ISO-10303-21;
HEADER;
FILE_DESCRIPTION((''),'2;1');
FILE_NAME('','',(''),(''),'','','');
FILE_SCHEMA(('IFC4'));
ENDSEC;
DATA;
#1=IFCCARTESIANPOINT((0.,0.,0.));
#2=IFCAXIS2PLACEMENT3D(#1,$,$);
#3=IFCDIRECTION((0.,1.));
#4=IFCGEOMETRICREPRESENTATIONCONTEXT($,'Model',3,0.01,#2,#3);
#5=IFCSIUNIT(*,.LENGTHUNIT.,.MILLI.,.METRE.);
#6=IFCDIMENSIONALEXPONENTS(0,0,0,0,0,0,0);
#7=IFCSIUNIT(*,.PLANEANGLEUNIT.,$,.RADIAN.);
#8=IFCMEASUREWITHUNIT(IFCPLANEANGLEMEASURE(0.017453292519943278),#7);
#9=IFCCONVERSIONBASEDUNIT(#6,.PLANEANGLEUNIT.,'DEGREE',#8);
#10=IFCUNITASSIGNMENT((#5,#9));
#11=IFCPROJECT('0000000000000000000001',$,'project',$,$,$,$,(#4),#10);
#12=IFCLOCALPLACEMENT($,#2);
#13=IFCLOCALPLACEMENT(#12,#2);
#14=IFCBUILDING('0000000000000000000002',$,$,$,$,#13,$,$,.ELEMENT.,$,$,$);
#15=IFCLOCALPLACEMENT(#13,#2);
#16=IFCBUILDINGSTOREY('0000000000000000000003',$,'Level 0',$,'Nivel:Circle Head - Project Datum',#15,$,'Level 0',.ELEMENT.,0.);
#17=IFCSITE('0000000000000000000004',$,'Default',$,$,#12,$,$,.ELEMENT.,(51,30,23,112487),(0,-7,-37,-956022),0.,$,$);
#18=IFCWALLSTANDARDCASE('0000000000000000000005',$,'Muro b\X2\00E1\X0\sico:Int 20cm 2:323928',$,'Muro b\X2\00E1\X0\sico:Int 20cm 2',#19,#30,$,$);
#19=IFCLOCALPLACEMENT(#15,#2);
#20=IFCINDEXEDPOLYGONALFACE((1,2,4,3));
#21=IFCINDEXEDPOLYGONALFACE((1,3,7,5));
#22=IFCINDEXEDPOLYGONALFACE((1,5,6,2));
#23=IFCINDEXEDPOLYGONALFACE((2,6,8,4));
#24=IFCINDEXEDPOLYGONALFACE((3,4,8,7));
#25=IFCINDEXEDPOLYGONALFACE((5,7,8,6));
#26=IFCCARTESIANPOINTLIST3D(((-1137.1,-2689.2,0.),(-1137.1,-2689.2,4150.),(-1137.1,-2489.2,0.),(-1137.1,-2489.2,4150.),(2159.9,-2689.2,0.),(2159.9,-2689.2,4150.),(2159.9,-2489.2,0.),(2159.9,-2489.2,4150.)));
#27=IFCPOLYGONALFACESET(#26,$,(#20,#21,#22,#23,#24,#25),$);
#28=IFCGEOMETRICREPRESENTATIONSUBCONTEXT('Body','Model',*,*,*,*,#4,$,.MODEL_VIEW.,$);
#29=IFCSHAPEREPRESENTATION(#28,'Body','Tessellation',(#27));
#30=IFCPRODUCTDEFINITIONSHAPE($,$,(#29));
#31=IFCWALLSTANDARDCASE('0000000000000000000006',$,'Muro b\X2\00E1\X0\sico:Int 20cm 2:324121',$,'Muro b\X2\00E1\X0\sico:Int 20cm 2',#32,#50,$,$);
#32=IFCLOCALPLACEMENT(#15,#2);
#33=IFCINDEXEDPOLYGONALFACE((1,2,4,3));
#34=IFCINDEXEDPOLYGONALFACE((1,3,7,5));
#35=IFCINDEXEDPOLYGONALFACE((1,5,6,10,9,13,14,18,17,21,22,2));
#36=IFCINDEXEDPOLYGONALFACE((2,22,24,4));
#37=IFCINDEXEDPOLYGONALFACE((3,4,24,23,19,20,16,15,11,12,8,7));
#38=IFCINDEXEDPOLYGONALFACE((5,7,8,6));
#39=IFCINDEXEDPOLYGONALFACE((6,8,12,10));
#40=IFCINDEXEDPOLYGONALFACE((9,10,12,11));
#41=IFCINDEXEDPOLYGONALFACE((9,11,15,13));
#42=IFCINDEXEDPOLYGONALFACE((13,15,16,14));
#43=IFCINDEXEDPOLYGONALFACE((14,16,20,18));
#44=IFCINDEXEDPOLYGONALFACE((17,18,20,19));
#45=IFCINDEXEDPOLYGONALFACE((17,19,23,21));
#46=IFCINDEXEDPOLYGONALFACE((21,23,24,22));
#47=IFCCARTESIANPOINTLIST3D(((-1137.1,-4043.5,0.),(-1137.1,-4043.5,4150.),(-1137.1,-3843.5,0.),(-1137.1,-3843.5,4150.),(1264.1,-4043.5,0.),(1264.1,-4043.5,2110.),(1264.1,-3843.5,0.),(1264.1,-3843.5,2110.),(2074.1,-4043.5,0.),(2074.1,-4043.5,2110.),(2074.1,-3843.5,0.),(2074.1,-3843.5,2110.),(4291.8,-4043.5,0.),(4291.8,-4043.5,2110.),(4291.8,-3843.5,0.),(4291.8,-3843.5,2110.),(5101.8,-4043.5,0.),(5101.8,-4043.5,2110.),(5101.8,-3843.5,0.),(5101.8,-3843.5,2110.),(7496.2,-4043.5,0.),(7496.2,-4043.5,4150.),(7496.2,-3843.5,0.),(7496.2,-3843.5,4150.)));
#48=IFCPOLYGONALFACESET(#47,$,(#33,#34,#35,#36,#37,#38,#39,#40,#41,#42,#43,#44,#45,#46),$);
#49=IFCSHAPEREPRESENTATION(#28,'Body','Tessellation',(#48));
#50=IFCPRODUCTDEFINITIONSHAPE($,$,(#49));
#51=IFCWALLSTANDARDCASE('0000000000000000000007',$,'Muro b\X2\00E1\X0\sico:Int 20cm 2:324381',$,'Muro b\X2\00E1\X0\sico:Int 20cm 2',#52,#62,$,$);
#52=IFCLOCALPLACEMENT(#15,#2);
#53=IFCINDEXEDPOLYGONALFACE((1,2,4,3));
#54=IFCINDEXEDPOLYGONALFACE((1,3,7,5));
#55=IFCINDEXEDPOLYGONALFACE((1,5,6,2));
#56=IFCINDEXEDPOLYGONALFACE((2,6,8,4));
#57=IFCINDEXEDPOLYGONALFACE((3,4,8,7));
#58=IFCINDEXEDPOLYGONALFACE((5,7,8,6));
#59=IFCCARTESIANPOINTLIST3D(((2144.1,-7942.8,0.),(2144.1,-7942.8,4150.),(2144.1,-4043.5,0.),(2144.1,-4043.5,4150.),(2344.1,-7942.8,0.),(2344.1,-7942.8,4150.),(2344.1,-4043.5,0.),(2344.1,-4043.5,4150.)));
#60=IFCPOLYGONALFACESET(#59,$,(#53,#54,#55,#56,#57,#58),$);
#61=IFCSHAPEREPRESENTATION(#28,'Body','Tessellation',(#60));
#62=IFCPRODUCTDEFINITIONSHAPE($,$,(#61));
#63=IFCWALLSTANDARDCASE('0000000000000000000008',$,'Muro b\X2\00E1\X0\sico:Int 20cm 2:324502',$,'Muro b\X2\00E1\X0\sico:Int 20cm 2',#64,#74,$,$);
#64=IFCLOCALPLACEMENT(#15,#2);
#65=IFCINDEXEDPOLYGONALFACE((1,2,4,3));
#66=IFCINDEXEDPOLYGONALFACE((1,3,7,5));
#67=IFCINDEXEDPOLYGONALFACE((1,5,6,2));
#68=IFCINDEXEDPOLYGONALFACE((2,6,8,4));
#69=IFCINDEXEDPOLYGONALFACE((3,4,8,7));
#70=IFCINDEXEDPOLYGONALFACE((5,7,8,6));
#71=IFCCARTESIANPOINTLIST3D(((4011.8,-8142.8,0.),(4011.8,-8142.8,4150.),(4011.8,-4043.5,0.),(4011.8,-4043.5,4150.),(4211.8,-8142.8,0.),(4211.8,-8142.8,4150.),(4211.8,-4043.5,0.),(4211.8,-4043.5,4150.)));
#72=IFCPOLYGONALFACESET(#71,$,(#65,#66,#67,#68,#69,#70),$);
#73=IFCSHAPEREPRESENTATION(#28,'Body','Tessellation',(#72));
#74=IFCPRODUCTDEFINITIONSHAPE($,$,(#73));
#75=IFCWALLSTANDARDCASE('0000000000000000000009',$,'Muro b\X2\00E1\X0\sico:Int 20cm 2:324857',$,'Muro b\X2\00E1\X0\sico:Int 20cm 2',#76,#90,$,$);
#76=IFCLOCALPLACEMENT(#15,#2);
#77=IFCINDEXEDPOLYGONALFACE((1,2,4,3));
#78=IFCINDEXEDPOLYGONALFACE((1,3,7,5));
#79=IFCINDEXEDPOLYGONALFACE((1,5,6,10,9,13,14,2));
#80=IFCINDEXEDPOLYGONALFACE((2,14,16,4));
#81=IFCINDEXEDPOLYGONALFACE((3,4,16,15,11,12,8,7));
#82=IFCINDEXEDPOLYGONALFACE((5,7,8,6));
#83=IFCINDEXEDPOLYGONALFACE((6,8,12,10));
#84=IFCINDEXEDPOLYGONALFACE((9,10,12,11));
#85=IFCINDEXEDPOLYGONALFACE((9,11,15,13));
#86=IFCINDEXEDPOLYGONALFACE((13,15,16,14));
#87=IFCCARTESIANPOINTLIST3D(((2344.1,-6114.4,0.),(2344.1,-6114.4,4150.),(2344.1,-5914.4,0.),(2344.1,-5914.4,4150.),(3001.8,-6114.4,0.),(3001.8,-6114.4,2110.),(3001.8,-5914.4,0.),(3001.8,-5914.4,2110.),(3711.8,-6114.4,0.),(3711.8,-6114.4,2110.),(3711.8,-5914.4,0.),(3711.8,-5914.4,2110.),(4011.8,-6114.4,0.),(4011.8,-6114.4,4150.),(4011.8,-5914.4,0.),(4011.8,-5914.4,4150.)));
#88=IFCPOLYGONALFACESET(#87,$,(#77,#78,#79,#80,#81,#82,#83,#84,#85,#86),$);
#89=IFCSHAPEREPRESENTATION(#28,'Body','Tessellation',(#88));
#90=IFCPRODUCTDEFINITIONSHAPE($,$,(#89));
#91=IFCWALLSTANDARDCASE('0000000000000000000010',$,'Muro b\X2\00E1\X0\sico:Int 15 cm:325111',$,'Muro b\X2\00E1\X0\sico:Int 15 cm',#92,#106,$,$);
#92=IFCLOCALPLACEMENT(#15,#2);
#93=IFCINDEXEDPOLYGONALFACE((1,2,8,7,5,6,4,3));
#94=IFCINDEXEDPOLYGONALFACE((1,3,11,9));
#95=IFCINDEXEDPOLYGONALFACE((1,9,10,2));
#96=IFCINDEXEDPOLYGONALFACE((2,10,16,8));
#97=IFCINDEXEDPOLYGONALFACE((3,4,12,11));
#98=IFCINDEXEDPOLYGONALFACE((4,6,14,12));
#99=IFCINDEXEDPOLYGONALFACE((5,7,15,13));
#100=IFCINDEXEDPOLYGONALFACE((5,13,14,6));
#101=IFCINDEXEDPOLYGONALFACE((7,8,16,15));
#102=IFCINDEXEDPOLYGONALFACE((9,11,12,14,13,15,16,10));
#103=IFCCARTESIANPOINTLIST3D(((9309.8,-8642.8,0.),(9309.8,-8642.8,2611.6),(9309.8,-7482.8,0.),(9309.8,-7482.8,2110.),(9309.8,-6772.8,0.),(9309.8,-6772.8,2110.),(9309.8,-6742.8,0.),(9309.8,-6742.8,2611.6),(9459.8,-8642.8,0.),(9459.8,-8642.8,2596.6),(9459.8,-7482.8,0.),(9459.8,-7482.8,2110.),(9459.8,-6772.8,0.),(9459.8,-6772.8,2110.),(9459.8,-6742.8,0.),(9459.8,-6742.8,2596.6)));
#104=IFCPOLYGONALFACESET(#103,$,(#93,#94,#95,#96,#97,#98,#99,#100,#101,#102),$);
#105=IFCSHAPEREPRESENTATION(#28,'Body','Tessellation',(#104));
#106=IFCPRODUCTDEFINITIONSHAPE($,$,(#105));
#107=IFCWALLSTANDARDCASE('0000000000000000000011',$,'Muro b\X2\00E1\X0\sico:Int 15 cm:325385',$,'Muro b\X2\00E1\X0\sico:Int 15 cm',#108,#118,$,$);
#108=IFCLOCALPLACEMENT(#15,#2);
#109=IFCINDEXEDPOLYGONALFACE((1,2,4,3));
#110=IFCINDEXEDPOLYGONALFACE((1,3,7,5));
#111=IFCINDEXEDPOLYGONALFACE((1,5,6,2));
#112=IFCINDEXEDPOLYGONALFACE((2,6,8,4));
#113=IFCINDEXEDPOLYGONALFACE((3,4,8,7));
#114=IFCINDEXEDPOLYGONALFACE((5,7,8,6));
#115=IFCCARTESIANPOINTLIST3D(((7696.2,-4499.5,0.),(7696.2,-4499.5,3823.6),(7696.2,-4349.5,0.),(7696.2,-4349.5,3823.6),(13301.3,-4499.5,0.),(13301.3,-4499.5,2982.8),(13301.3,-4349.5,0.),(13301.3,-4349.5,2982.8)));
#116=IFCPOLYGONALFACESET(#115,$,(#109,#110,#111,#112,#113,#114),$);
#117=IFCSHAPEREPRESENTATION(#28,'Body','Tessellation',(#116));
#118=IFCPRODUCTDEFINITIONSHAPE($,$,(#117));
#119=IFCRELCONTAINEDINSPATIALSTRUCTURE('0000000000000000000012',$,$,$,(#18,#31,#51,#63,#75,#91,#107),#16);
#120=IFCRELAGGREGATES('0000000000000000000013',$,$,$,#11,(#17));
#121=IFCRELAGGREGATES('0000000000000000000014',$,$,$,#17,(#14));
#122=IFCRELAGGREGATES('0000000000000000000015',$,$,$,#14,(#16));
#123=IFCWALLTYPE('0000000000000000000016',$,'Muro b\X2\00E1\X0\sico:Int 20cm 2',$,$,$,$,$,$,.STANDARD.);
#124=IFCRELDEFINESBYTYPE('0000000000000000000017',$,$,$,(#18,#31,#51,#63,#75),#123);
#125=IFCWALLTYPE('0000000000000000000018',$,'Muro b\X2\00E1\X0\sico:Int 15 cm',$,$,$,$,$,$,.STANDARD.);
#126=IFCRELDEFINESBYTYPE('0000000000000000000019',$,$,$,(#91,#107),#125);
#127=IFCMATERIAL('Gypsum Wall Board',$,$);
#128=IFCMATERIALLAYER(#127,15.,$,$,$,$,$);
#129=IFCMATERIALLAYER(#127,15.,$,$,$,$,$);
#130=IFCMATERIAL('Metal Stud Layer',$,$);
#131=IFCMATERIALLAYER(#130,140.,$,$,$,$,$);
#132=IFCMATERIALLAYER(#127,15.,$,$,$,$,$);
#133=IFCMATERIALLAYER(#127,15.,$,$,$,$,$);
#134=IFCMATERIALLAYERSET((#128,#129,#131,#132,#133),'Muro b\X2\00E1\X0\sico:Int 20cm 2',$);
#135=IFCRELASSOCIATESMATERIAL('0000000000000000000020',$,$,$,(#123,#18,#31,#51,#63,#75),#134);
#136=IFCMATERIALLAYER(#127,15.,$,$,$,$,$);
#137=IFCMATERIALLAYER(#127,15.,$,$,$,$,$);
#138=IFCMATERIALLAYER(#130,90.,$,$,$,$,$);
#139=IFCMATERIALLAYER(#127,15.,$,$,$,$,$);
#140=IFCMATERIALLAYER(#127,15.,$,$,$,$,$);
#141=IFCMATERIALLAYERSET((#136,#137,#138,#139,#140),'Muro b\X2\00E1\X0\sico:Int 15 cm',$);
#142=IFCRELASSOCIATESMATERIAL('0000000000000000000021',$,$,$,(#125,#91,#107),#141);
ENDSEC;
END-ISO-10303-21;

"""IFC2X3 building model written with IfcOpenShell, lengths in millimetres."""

from ifc_helpers import new_model, entity, si_unit, converted_unit, direction, frame, frame_2d, origin, place, context, subcontext, project, spatial, polyline, rectangle, extrude, clip, bounded_halfspace, material, layer, layer_set, layer_usage, type_object, element, save


model = new_model("IFC2X3")

# Units and contexts
model_context = context("Model", 3, precision=0.01, world=origin(), true_north=direction((0.0, 1.0)))
body_context = subcontext(model_context, "Body", "Model", "MODEL_VIEW")
ifc_project = project(units=[si_unit("LENGTHUNIT", "METRE", prefix="MILLI"), converted_unit("PLANEANGLEUNIT", "DEGREE", entity("IfcPlaneAngleMeasure", 0.017453292519943278), si_unit("PLANEANGLEUNIT", "RADIAN"), dimensions=[0, 0, 0, 0, 0, 0, 0])], contexts=[model_context])

# Site, building, storey
site_placement = place(None, origin())
site = spatial("IfcSite", under=ifc_project, at=site_placement, Name="Default", CompositionType="ELEMENT", RefLatitude=(51, 30, 23, 112487), RefLongitude=(0, -7, -37, -956022), RefElevation=0.0)
building_placement = place(site_placement, origin())
building = spatial("IfcBuilding", under=site, at=building_placement, CompositionType="ELEMENT")
storey_placement = place(building_placement, origin())
storey = spatial("IfcBuildingStorey", under=building, at=storey_placement, Name="Level 0", ObjectType="Nivel:Circle Head - Project Datum", LongName="Level 0", CompositionType="ELEMENT", Elevation=0.0)

# Shared definitions
ifc_material_1 = material(Name="Gypsum Wall Board")
ifc_material_2 = material(Name="Metal Stud Layer")

# Wall
ifc_layer_1 = layer(ifc_material_1, 15.0)
ifc_layer_2 = layer(ifc_material_1, 15.0)
ifc_layer_3 = layer(ifc_material_2, 140.0)
ifc_layer_4 = layer(ifc_material_1, 15.0)
ifc_layer_5 = layer(ifc_material_1, 15.0)
ifc_layer_set_1 = layer_set([ifc_layer_1, ifc_layer_2, ifc_layer_3, ifc_layer_4, ifc_layer_5], Name="Muro básico:Int 20cm 2")
ifc_layer_usage_1 = layer_usage(ifc_layer_set_1, "AXIS2", "NEGATIVE", 100.0)
wall_type_1 = type_object("IfcWallType", Name="Muro básico:Int 20cm 2", PredefinedType="STANDARD", material=ifc_layer_set_1)
wall_1_placement = place(storey_placement, frame((-1137.1, -2589.2, 0.0)))
element("IfcWallStandardCase", 1, at=wall_1_placement, inside=storey, type_object=wall_type_1, material=ifc_layer_usage_1, Name="Muro básico:Int 20cm 2:323928", ObjectType="Muro básico:Int 20cm 2", context=body_context, shape_type="SweptSolid", body=[
    extrude(rectangle(XDim=3297.0, YDim=200.0, at=frame_2d((1648.5, 0.0), x_axis=(-1.0, 0.0))), origin(), (0.0, 0.0, 1.0), 4150.0),
])

# Wall, openings
ifc_layer_usage_2 = layer_usage(ifc_layer_set_1, "AXIS2", "NEGATIVE", 100.0)
wall_2_placement = place(storey_placement, frame((-1137.1, -3943.5, 0.0)))
wall_2 = element("IfcWallStandardCase", 2, at=wall_2_placement, inside=storey, type_object=wall_type_1, material=ifc_layer_usage_2, Name="Muro básico:Int 20cm 2:324121", ObjectType="Muro básico:Int 20cm 2", context=body_context, shape_type="SweptSolid", body=[
    extrude(rectangle(XDim=8633.4, YDim=200.0, at=frame_2d((4316.7, 0.0), x_axis=(-1.0, 0.0))), origin(), (0.0, 0.0, 1.0), 4150.0),
])
opening_1_placement = place(wall_2_placement, frame((3211.2, 100.0, 0.0)))
element("IfcOpeningElement", 3, at=opening_1_placement, cuts=wall_2, ObjectType="Opening", context=body_context, shape_type="SweptSolid", body=[
    extrude(rectangle(XDim=2110.0, YDim=810.0, at=frame_2d((1055.0, 405.0), x_axis=(1.0, 0.0))), frame((0.0, 0.0, 0.0), z_axis=(0.0, -1.0, 0.0), x_axis=(0.0, 0.0, 1.0)), (0.0, 0.0, 1.0), 200.0),
])
opening_2_placement = place(wall_2_placement, frame((6238.9, 100.0, 0.0)))
element("IfcOpeningElement", 4, at=opening_2_placement, cuts=wall_2, ObjectType="Opening", context=body_context, shape_type="SweptSolid", body=[
    extrude(rectangle(XDim=2110.0, YDim=810.0, at=frame_2d((1055.0, 405.0), x_axis=(1.0, 0.0))), frame((0.0, 0.0, 0.0), z_axis=(0.0, -1.0, 0.0), x_axis=(0.0, 0.0, 1.0)), (0.0, 0.0, 1.0), 200.0),
])

# Walls
ifc_layer_usage_3 = layer_usage(ifc_layer_set_1, "AXIS2", "NEGATIVE", 100.0)
wall_3_placement = place(storey_placement, frame((2244.1, -7942.8, 0.0), z_axis=(0.0, 0.0, 1.0), x_axis=(0.0, 1.0, 0.0)))
element("IfcWallStandardCase", 5, at=wall_3_placement, inside=storey, type_object=wall_type_1, material=ifc_layer_usage_3, Name="Muro básico:Int 20cm 2:324381", ObjectType="Muro básico:Int 20cm 2", context=body_context, shape_type="SweptSolid", body=[
    extrude(rectangle(XDim=3899.3, YDim=200.0, at=frame_2d((1949.6, 0.0), x_axis=(-1.0, 0.0))), origin(), (0.0, 0.0, 1.0), 4150.0),
])
ifc_layer_usage_4 = layer_usage(ifc_layer_set_1, "AXIS2", "NEGATIVE", 100.0)
wall_4_placement = place(storey_placement, frame((4111.8, -8142.8, 0.0), z_axis=(0.0, 0.0, 1.0), x_axis=(0.0, 1.0, 0.0)))
element("IfcWallStandardCase", 6, at=wall_4_placement, inside=storey, type_object=wall_type_1, material=ifc_layer_usage_4, Name="Muro básico:Int 20cm 2:324502", ObjectType="Muro básico:Int 20cm 2", context=body_context, shape_type="SweptSolid", body=[
    extrude(rectangle(XDim=4099.3, YDim=200.0, at=frame_2d((2049.6, 0.0), x_axis=(-1.0, 0.0))), origin(), (0.0, 0.0, 1.0), 4150.0),
])

# Walls, openings
ifc_layer_usage_5 = layer_usage(ifc_layer_set_1, "AXIS2", "NEGATIVE", 100.0)
wall_5_placement = place(storey_placement, frame((4011.8, -6014.4, 0.0), z_axis=(0.0, 0.0, 1.0), x_axis=(-1.0, 0.0, 0.0)))
wall_5 = element("IfcWallStandardCase", 7, at=wall_5_placement, inside=storey, type_object=wall_type_1, material=ifc_layer_usage_5, Name="Muro básico:Int 20cm 2:324857", ObjectType="Muro básico:Int 20cm 2", context=body_context, shape_type="SweptSolid", body=[
    extrude(rectangle(XDim=1667.7, YDim=200.0, at=frame_2d((833.8, 0.0), x_axis=(-1.0, 0.0))), origin(), (0.0, 0.0, 1.0), 4150.0),
])
opening_3_placement = place(wall_5_placement, frame((300.0, -100.0, 0.0)))
element("IfcOpeningElement", 8, at=opening_3_placement, cuts=wall_5, ObjectType="Opening", context=body_context, shape_type="SweptSolid", body=[
    extrude(rectangle(XDim=2110.0, YDim=710.0, at=frame_2d((1055.0, 355.0), x_axis=(1.0, 0.0))), frame((0.0, 0.0, 0.0), z_axis=(0.0, 1.0, 0.0), x_axis=(0.0, 0.0, 1.0)), (0.0, 0.0, 1.0), 200.0),
])
ifc_layer_6 = layer(ifc_material_1, 15.0)
ifc_layer_7 = layer(ifc_material_1, 15.0)
ifc_layer_8 = layer(ifc_material_2, 90.0)
ifc_layer_9 = layer(ifc_material_1, 15.0)
ifc_layer_10 = layer(ifc_material_1, 15.0)
ifc_layer_set_2 = layer_set([ifc_layer_6, ifc_layer_7, ifc_layer_8, ifc_layer_9, ifc_layer_10], Name="Muro básico:Int 15 cm")
ifc_layer_usage_6 = layer_usage(ifc_layer_set_2, "AXIS2", "NEGATIVE", 75.0)
wall_type_2 = type_object("IfcWallType", Name="Muro básico:Int 15 cm", PredefinedType="STANDARD", material=ifc_layer_set_2)
wall_6_placement = place(storey_placement, frame((9384.8, -8642.8, 0.0), z_axis=(0.0, 0.0, 1.0), x_axis=(0.0, 1.0, 0.0)))
wall_6 = element("IfcWallStandardCase", 9, at=wall_6_placement, inside=storey, type_object=wall_type_2, material=ifc_layer_usage_6, Name="Muro básico:Int 15 cm:325111", ObjectType="Muro básico:Int 15 cm", context=body_context, shape_type="Clipping", body=[
    clip(extrude(rectangle(XDim=1900.0, YDim=150.0, at=frame_2d((950.0, 0.0), x_axis=(1.0, 0.0))), origin(), (0.0, 0.0, 1.0), 2611.6), bounded_halfspace(frame((0.0, -75.0, 2596.6), z_axis=(0.0, -0.099504, 0.995037), x_axis=(1.0, 0.0, 0.0)), False, frame((0.0, -75.0, 2596.6)), polyline([(0.0, 0.0), (1900.0, 0.0), (1900.0, 150.0), (0.0, 150.0), (0.0, 0.0)]))),
])
opening_4_placement = place(wall_6_placement, frame((1870.0, 75.0, 0.0)))
element("IfcOpeningElement", 10, at=opening_4_placement, cuts=wall_6, ObjectType="Opening", context=body_context, shape_type="SweptSolid", body=[
    extrude(rectangle(XDim=2110.0, YDim=710.0, at=frame_2d((1055.0, 355.0), x_axis=(1.0, 0.0))), frame((0.0, 0.0, 0.0), z_axis=(0.0, -1.0, 0.0), x_axis=(0.0, 0.0, 1.0)), (0.0, 0.0, 1.0), 150.0),
])

# Wall
ifc_layer_usage_7 = layer_usage(ifc_layer_set_2, "AXIS2", "NEGATIVE", 75.0)
wall_7_placement = place(storey_placement, frame((7696.2, -4424.5, 0.0)))
element("IfcWallStandardCase", 11, at=wall_7_placement, inside=storey, type_object=wall_type_2, material=ifc_layer_usage_7, Name="Muro básico:Int 15 cm:325385", ObjectType="Muro básico:Int 15 cm", context=body_context, shape_type="Clipping", body=[
    clip(extrude(rectangle(XDim=5605.1, YDim=150.0, at=frame_2d((2802.6, 0.0), x_axis=(-1.0, 0.0))), origin(), (0.0, 0.0, 1.0), 3823.6), bounded_halfspace(frame((0.0, -75.0, 3823.6), z_axis=(0.14834, 0.0, 0.988936), x_axis=(0.0, 1.0, 0.0)), False, frame((0.0, -75.0, 3823.6)), polyline([(0.0, 0.0), (5605.1, 0.0), (5605.1, 150.0), (0.0, 150.0), (0.0, 0.0)]))),
])

save(model, "model.ifc")
